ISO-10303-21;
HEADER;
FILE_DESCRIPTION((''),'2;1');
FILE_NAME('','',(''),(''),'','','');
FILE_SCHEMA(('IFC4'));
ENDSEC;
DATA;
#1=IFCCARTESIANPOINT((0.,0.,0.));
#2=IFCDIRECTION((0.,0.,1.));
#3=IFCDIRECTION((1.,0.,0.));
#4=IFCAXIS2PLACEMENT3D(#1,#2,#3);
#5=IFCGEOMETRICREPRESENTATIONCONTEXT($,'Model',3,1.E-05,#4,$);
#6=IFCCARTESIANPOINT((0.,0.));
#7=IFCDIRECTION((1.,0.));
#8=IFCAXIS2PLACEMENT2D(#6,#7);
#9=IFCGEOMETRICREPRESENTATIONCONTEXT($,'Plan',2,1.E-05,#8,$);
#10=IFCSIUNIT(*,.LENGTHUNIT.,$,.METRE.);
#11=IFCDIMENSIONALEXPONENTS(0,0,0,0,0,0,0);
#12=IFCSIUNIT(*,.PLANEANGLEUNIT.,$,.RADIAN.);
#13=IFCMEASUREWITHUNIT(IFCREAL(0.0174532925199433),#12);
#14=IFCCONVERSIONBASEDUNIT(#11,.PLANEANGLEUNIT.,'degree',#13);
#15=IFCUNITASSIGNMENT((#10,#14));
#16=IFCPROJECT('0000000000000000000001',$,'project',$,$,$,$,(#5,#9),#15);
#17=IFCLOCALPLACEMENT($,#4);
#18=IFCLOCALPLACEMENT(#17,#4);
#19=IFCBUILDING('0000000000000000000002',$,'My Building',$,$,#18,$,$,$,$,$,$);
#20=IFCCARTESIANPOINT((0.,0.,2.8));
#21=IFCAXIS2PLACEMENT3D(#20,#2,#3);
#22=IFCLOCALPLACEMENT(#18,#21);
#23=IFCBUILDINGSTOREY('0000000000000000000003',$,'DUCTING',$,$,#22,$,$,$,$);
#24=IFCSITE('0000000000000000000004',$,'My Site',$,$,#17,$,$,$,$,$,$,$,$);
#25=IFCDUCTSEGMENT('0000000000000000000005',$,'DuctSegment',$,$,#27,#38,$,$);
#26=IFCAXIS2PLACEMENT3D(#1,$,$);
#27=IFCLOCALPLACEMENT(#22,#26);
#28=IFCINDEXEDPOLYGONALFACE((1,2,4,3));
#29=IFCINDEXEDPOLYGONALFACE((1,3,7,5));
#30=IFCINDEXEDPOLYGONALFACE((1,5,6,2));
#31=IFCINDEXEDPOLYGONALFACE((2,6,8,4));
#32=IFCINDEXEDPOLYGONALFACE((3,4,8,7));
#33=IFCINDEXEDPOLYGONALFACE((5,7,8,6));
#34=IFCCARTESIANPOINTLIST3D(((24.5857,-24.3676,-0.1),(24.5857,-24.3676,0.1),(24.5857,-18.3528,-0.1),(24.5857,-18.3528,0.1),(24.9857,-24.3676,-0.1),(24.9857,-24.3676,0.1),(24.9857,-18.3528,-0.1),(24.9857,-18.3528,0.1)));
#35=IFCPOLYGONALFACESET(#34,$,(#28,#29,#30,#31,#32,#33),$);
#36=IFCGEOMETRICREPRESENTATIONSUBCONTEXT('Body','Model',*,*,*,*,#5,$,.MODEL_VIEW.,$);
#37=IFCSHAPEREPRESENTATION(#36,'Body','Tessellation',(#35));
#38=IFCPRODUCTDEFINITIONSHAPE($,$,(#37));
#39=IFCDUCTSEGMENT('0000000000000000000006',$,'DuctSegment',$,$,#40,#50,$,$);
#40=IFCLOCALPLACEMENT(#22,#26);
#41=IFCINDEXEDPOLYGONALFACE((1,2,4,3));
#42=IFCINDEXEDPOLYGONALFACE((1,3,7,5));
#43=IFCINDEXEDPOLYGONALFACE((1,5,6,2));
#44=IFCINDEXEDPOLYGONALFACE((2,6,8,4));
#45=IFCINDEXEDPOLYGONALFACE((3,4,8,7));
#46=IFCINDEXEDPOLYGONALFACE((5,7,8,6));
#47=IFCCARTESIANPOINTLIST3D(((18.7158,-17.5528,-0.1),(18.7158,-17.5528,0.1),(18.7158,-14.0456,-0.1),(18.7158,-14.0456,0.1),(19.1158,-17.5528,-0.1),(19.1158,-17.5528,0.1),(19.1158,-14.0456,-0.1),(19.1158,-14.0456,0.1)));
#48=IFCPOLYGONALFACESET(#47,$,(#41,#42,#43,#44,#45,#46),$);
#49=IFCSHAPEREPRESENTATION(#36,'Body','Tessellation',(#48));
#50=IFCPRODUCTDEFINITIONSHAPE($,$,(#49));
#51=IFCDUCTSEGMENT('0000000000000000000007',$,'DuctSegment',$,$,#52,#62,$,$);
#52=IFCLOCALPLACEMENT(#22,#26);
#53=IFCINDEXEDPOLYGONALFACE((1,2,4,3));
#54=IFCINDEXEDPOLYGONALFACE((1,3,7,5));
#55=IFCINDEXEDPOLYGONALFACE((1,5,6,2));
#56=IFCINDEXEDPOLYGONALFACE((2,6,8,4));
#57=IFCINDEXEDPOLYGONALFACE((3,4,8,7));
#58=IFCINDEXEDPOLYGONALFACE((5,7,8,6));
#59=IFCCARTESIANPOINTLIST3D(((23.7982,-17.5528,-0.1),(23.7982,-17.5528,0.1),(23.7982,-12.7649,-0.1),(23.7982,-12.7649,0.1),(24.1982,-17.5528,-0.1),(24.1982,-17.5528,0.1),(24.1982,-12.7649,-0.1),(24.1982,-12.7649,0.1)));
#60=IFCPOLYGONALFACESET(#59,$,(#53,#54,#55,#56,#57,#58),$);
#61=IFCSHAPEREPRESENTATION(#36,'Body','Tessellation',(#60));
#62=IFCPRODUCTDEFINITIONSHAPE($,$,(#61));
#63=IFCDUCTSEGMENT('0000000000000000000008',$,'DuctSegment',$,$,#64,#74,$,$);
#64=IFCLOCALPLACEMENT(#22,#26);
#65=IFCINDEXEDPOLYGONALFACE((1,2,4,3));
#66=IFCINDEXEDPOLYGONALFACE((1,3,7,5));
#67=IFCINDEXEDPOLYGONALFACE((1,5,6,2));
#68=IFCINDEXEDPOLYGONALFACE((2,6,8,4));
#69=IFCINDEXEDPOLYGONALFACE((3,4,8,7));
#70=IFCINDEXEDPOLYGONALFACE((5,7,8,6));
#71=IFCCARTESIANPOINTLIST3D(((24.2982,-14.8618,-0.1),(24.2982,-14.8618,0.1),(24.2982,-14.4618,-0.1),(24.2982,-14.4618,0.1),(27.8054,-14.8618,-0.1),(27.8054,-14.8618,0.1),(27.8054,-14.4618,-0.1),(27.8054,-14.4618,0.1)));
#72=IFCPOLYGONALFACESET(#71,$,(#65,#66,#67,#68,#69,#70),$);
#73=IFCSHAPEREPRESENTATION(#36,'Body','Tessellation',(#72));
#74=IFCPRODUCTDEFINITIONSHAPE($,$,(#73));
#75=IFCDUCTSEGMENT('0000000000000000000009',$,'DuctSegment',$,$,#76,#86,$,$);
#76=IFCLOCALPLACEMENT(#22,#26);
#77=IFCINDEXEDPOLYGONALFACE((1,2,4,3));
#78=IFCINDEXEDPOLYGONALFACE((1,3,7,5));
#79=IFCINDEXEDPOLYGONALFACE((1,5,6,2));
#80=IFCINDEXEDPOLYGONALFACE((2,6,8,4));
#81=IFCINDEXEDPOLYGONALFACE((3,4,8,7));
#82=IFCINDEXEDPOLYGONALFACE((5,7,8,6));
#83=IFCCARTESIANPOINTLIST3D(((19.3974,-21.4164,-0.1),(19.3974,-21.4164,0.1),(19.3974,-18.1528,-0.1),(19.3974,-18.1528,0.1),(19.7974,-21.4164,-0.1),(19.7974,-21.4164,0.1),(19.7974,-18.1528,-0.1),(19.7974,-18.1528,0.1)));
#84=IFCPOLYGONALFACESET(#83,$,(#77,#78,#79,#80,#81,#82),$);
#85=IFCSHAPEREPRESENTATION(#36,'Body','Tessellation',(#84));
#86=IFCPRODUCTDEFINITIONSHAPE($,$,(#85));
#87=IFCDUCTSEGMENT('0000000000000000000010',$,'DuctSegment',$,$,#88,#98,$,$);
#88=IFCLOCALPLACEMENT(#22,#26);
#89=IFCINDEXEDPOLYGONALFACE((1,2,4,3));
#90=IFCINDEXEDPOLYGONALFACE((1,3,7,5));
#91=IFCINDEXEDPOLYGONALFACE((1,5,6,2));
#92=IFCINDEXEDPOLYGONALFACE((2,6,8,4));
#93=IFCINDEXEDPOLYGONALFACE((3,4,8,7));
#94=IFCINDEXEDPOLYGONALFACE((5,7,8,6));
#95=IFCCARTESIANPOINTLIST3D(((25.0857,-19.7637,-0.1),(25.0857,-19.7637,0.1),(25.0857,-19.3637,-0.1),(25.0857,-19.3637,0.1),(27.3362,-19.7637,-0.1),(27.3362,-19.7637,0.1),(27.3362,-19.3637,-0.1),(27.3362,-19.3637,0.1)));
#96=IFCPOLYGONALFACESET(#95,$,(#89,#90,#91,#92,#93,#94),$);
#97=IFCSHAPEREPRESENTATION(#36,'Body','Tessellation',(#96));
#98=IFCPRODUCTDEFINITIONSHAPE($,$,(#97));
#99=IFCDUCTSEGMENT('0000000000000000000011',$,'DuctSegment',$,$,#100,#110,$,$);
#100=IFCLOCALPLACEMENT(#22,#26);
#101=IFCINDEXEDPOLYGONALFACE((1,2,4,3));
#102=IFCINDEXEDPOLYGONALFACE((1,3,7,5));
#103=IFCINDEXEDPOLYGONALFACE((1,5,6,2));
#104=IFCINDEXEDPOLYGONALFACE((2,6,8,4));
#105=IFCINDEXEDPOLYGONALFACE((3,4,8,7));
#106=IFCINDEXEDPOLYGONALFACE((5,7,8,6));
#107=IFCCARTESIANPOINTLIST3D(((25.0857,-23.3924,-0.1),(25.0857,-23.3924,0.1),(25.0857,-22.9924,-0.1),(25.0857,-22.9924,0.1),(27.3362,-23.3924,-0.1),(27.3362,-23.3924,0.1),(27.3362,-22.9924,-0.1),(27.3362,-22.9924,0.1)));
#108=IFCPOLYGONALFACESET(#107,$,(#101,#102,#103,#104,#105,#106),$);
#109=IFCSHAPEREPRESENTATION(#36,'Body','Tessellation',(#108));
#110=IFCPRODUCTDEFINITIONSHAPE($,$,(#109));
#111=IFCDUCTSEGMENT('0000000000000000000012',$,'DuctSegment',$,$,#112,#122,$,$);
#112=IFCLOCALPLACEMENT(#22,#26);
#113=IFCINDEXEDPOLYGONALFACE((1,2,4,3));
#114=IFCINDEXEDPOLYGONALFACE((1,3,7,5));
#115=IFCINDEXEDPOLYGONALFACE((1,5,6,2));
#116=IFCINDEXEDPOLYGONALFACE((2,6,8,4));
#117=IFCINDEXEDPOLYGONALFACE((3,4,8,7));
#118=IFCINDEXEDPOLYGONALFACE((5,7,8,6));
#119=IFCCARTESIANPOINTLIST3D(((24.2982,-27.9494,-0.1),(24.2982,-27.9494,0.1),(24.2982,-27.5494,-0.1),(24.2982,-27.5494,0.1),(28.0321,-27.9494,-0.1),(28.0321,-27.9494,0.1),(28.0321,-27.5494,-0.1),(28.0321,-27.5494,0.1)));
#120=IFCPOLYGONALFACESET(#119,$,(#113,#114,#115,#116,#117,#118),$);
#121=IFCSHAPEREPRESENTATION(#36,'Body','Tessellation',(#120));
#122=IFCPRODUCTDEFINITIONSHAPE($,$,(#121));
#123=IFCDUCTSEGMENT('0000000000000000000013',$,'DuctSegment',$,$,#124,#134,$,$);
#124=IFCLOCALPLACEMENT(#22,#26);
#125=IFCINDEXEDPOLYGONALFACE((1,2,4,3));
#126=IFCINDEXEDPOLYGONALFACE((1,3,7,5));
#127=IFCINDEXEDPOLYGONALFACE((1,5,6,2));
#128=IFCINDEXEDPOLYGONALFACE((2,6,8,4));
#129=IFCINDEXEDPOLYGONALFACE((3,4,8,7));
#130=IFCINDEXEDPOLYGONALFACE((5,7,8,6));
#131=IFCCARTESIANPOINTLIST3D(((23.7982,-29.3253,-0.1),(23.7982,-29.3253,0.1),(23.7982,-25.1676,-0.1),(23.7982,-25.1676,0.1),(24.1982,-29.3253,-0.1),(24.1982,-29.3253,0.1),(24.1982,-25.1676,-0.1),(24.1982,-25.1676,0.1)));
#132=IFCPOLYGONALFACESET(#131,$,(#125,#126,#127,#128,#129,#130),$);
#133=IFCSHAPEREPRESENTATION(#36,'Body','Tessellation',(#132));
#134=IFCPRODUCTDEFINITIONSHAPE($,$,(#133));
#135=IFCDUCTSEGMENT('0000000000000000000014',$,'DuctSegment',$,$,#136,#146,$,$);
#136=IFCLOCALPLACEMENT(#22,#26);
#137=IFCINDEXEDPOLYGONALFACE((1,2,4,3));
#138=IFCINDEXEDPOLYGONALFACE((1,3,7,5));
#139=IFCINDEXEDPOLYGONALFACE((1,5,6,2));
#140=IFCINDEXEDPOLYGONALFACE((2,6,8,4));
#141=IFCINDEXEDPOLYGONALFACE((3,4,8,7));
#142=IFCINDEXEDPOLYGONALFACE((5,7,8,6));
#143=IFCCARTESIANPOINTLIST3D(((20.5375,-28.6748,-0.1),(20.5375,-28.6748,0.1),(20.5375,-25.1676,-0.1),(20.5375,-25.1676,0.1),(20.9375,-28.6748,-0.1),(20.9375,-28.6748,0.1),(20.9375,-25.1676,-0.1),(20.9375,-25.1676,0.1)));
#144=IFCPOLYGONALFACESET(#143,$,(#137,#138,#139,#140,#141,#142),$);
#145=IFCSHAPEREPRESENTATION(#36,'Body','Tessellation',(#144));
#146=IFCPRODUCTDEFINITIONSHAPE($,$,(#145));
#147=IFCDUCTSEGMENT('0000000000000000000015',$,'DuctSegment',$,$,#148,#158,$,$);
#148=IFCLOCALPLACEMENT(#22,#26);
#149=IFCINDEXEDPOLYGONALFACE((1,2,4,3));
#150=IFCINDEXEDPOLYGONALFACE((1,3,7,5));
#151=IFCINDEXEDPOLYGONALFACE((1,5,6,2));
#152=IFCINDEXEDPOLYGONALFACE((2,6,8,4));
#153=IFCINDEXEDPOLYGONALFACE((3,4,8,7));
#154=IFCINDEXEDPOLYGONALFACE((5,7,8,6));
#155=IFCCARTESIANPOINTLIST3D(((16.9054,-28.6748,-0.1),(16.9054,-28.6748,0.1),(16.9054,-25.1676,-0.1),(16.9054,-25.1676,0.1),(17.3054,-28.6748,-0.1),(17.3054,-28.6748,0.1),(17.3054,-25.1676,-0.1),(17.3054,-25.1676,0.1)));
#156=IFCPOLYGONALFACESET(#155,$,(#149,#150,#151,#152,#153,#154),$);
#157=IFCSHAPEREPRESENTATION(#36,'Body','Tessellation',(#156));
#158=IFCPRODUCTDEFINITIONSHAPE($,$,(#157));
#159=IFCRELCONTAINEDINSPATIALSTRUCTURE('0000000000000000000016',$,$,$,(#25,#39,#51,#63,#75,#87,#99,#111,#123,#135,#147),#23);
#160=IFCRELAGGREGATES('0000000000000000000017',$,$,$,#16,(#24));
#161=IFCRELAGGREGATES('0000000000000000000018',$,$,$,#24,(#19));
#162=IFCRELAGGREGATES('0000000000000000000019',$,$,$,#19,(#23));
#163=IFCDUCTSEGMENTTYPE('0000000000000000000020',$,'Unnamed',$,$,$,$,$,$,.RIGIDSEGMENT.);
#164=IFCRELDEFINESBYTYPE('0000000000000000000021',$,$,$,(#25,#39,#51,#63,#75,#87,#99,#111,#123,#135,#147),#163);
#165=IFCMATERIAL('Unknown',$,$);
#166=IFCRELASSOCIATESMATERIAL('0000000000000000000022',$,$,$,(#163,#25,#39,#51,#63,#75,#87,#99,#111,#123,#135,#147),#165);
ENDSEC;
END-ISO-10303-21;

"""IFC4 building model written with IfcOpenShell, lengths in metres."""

from ifc_helpers import new_model, entity, si_unit, converted_unit, frame, origin_with_axes, origin_2d_with_axis, place, context, subcontext, project, spatial, rectangle, extrude, material, material_profile, profile_set, profile_usage, type_object, element, save


model = new_model("IFC4")

# Units and contexts
model_context = context("Model", 3, precision=1e-05, world=origin_with_axes())
plan_context = context("Plan", 2, precision=1e-05, world=origin_2d_with_axis())
body_context = subcontext(model_context, "Body", "Model", "MODEL_VIEW")
ifc_project = project(units=[si_unit("LENGTHUNIT", "METRE"), converted_unit("PLANEANGLEUNIT", "degree", entity("IfcReal", 0.0174532925199433), si_unit("PLANEANGLEUNIT", "RADIAN"), dimensions=[0, 0, 0, 0, 0, 0, 0])], contexts=[model_context, plan_context])

# Site, building, storey
site_placement = place(None, origin_with_axes())
site = spatial("IfcSite", under=ifc_project, at=site_placement, Name="My Site")
building_placement = place(site_placement, origin_with_axes())
building = spatial("IfcBuilding", under=site, at=building_placement, Name="My Building")
storey_placement = place(building_placement, frame((0.0, 0.0, 2.8), z_axis=(0.0, 0.0, 1.0), x_axis=(1.0, 0.0, 0.0)))
storey = spatial("IfcBuildingStorey", under=building, at=storey_placement, Name="DUCTING")

# Duct segments
ifc_material = material(Name="Unknown")
ifc_material_profile_1 = material_profile(ifc_material, rectangle(XDim=0.4, YDim=0.2))
ifc_profile_set_1 = profile_set([ifc_material_profile_1])
ifc_profile_usage_1 = profile_usage(ifc_profile_set_1, cardinal=5)
duct_segment_type = type_object("IfcDuctSegmentType", Name="Unnamed", PredefinedType="RIGIDSEGMENT", material=ifc_profile_set_1)
duct_segment_1_placement = place(storey_placement, frame((24.7857, -18.3528, 0.0), z_axis=(0.0, -1.0, 0.0), x_axis=(1.0, 0.0, 0.0)))
element("IfcDuctSegment", 1, at=duct_segment_1_placement, inside=storey, type_object=duct_segment_type, material=ifc_profile_usage_1, Name="DuctSegment", context=body_context, shape_type="SweptSolid", body=[
    extrude(rectangle(XDim=0.4, YDim=0.2), origin_with_axes(), (0.0, 0.0, 1.0), 6.0148),
])
ifc_profile_usage_2 = profile_usage(ifc_profile_set_1, cardinal=5)
duct_segment_2_placement = place(storey_placement, frame((18.9158, -17.5528, 0.0), z_axis=(0.0, 1.0, 0.0), x_axis=(-1.0, 0.0, 0.0)))
element("IfcDuctSegment", 2, at=duct_segment_2_placement, inside=storey, type_object=duct_segment_type, material=ifc_profile_usage_2, Name="DuctSegment", context=body_context, shape_type="SweptSolid", body=[
    extrude(rectangle(XDim=0.4, YDim=0.2), origin_with_axes(), (0.0, 0.0, 1.0), 3.5072),
])
ifc_profile_usage_3 = profile_usage(ifc_profile_set_1, cardinal=5)
duct_segment_3_placement = place(storey_placement, frame((23.9982, -17.5528, 0.0), z_axis=(0.0, 1.0, 0.0), x_axis=(-1.0, 0.0, 0.0)))
element("IfcDuctSegment", 3, at=duct_segment_3_placement, inside=storey, type_object=duct_segment_type, material=ifc_profile_usage_3, Name="DuctSegment", context=body_context, shape_type="SweptSolid", body=[
    extrude(rectangle(XDim=0.4, YDim=0.2), origin_with_axes(), (0.0, 0.0, 1.0), 4.7879),
])
ifc_profile_usage_4 = profile_usage(ifc_profile_set_1, cardinal=5)
duct_segment_4_placement = place(storey_placement, frame((24.2982, -14.6618, 0.0), z_axis=(1.0, 0.0, 0.0), x_axis=(0.0, 1.0, 0.0)))
element("IfcDuctSegment", 4, at=duct_segment_4_placement, inside=storey, type_object=duct_segment_type, material=ifc_profile_usage_4, Name="DuctSegment", context=body_context, shape_type="SweptSolid", body=[
    extrude(rectangle(XDim=0.4, YDim=0.2), origin_with_axes(), (0.0, 0.0, 1.0), 3.5072),
])
ifc_profile_usage_5 = profile_usage(ifc_profile_set_1, cardinal=5)
duct_segment_5_placement = place(storey_placement, frame((19.5974, -18.1528, 0.0), z_axis=(0.0, -1.0, 0.0), x_axis=(1.0, 0.0, 0.0)))
element("IfcDuctSegment", 5, at=duct_segment_5_placement, inside=storey, type_object=duct_segment_type, material=ifc_profile_usage_5, Name="DuctSegment", context=body_context, shape_type="SweptSolid", body=[
    extrude(rectangle(XDim=0.4, YDim=0.2), origin_with_axes(), (0.0, 0.0, 1.0), 3.2636),
])
ifc_profile_usage_6 = profile_usage(ifc_profile_set_1, cardinal=5)
duct_segment_6_placement = place(storey_placement, frame((25.0857, -19.5637, 0.0), z_axis=(1.0, 0.0, 0.0), x_axis=(0.0, 1.0, 0.0)))
element("IfcDuctSegment", 6, at=duct_segment_6_placement, inside=storey, type_object=duct_segment_type, material=ifc_profile_usage_6, Name="DuctSegment", context=body_context, shape_type="SweptSolid", body=[
    extrude(rectangle(XDim=0.4, YDim=0.2), origin_with_axes(), (0.0, 0.0, 1.0), 2.2505),
])
ifc_profile_usage_7 = profile_usage(ifc_profile_set_1, cardinal=5)
duct_segment_7_placement = place(storey_placement, frame((25.0857, -23.1924, 0.0), z_axis=(1.0, 0.0, 0.0), x_axis=(0.0, 1.0, 0.0)))
element("IfcDuctSegment", 7, at=duct_segment_7_placement, inside=storey, type_object=duct_segment_type, material=ifc_profile_usage_7, Name="DuctSegment", context=body_context, shape_type="SweptSolid", body=[
    extrude(rectangle(XDim=0.4, YDim=0.2), origin_with_axes(), (0.0, 0.0, 1.0), 2.2505),
])
ifc_profile_usage_8 = profile_usage(ifc_profile_set_1, cardinal=5)
duct_segment_8_placement = place(storey_placement, frame((24.2982, -27.7494, 0.0), z_axis=(1.0, 0.0, 0.0), x_axis=(0.0, 1.0, 0.0)))
element("IfcDuctSegment", 8, at=duct_segment_8_placement, inside=storey, type_object=duct_segment_type, material=ifc_profile_usage_8, Name="DuctSegment", context=body_context, shape_type="SweptSolid", body=[
    extrude(rectangle(XDim=0.4, YDim=0.2), origin_with_axes(), (0.0, 0.0, 1.0), 3.734),
])
ifc_profile_usage_9 = profile_usage(ifc_profile_set_1, cardinal=5)
duct_segment_9_placement = place(storey_placement, frame((23.9982, -25.1676, 0.0), z_axis=(0.0, -1.0, 0.0), x_axis=(1.0, 0.0, 0.0)))
element("IfcDuctSegment", 9, at=duct_segment_9_placement, inside=storey, type_object=duct_segment_type, material=ifc_profile_usage_9, Name="DuctSegment", context=body_context, shape_type="SweptSolid", body=[
    extrude(rectangle(XDim=0.4, YDim=0.2), origin_with_axes(), (0.0, 0.0, 1.0), 4.1577),
])
ifc_profile_usage_10 = profile_usage(ifc_profile_set_1, cardinal=5)
duct_segment_10_placement = place(storey_placement, frame((20.7375, -25.1676, 0.0), z_axis=(0.0, -1.0, 0.0), x_axis=(1.0, 0.0, 0.0)))
element("IfcDuctSegment", 10, at=duct_segment_10_placement, inside=storey, type_object=duct_segment_type, material=ifc_profile_usage_10, Name="DuctSegment", context=body_context, shape_type="SweptSolid", body=[
    extrude(rectangle(XDim=0.4, YDim=0.2), origin_with_axes(), (0.0, 0.0, 1.0), 3.5072),
])
ifc_profile_usage_11 = profile_usage(ifc_profile_set_1, cardinal=5)
duct_segment_11_placement = place(storey_placement, frame((17.1054, -25.1676, 0.0), z_axis=(0.0, -1.0, 0.0), x_axis=(1.0, 0.0, 0.0)))
element("IfcDuctSegment", 11, at=duct_segment_11_placement, inside=storey, type_object=duct_segment_type, material=ifc_profile_usage_11, Name="DuctSegment", context=body_context, shape_type="SweptSolid", body=[
    extrude(rectangle(XDim=0.4, YDim=0.2), origin_with_axes(), (0.0, 0.0, 1.0), 3.5072),
])

save(model, "model.ifc")
